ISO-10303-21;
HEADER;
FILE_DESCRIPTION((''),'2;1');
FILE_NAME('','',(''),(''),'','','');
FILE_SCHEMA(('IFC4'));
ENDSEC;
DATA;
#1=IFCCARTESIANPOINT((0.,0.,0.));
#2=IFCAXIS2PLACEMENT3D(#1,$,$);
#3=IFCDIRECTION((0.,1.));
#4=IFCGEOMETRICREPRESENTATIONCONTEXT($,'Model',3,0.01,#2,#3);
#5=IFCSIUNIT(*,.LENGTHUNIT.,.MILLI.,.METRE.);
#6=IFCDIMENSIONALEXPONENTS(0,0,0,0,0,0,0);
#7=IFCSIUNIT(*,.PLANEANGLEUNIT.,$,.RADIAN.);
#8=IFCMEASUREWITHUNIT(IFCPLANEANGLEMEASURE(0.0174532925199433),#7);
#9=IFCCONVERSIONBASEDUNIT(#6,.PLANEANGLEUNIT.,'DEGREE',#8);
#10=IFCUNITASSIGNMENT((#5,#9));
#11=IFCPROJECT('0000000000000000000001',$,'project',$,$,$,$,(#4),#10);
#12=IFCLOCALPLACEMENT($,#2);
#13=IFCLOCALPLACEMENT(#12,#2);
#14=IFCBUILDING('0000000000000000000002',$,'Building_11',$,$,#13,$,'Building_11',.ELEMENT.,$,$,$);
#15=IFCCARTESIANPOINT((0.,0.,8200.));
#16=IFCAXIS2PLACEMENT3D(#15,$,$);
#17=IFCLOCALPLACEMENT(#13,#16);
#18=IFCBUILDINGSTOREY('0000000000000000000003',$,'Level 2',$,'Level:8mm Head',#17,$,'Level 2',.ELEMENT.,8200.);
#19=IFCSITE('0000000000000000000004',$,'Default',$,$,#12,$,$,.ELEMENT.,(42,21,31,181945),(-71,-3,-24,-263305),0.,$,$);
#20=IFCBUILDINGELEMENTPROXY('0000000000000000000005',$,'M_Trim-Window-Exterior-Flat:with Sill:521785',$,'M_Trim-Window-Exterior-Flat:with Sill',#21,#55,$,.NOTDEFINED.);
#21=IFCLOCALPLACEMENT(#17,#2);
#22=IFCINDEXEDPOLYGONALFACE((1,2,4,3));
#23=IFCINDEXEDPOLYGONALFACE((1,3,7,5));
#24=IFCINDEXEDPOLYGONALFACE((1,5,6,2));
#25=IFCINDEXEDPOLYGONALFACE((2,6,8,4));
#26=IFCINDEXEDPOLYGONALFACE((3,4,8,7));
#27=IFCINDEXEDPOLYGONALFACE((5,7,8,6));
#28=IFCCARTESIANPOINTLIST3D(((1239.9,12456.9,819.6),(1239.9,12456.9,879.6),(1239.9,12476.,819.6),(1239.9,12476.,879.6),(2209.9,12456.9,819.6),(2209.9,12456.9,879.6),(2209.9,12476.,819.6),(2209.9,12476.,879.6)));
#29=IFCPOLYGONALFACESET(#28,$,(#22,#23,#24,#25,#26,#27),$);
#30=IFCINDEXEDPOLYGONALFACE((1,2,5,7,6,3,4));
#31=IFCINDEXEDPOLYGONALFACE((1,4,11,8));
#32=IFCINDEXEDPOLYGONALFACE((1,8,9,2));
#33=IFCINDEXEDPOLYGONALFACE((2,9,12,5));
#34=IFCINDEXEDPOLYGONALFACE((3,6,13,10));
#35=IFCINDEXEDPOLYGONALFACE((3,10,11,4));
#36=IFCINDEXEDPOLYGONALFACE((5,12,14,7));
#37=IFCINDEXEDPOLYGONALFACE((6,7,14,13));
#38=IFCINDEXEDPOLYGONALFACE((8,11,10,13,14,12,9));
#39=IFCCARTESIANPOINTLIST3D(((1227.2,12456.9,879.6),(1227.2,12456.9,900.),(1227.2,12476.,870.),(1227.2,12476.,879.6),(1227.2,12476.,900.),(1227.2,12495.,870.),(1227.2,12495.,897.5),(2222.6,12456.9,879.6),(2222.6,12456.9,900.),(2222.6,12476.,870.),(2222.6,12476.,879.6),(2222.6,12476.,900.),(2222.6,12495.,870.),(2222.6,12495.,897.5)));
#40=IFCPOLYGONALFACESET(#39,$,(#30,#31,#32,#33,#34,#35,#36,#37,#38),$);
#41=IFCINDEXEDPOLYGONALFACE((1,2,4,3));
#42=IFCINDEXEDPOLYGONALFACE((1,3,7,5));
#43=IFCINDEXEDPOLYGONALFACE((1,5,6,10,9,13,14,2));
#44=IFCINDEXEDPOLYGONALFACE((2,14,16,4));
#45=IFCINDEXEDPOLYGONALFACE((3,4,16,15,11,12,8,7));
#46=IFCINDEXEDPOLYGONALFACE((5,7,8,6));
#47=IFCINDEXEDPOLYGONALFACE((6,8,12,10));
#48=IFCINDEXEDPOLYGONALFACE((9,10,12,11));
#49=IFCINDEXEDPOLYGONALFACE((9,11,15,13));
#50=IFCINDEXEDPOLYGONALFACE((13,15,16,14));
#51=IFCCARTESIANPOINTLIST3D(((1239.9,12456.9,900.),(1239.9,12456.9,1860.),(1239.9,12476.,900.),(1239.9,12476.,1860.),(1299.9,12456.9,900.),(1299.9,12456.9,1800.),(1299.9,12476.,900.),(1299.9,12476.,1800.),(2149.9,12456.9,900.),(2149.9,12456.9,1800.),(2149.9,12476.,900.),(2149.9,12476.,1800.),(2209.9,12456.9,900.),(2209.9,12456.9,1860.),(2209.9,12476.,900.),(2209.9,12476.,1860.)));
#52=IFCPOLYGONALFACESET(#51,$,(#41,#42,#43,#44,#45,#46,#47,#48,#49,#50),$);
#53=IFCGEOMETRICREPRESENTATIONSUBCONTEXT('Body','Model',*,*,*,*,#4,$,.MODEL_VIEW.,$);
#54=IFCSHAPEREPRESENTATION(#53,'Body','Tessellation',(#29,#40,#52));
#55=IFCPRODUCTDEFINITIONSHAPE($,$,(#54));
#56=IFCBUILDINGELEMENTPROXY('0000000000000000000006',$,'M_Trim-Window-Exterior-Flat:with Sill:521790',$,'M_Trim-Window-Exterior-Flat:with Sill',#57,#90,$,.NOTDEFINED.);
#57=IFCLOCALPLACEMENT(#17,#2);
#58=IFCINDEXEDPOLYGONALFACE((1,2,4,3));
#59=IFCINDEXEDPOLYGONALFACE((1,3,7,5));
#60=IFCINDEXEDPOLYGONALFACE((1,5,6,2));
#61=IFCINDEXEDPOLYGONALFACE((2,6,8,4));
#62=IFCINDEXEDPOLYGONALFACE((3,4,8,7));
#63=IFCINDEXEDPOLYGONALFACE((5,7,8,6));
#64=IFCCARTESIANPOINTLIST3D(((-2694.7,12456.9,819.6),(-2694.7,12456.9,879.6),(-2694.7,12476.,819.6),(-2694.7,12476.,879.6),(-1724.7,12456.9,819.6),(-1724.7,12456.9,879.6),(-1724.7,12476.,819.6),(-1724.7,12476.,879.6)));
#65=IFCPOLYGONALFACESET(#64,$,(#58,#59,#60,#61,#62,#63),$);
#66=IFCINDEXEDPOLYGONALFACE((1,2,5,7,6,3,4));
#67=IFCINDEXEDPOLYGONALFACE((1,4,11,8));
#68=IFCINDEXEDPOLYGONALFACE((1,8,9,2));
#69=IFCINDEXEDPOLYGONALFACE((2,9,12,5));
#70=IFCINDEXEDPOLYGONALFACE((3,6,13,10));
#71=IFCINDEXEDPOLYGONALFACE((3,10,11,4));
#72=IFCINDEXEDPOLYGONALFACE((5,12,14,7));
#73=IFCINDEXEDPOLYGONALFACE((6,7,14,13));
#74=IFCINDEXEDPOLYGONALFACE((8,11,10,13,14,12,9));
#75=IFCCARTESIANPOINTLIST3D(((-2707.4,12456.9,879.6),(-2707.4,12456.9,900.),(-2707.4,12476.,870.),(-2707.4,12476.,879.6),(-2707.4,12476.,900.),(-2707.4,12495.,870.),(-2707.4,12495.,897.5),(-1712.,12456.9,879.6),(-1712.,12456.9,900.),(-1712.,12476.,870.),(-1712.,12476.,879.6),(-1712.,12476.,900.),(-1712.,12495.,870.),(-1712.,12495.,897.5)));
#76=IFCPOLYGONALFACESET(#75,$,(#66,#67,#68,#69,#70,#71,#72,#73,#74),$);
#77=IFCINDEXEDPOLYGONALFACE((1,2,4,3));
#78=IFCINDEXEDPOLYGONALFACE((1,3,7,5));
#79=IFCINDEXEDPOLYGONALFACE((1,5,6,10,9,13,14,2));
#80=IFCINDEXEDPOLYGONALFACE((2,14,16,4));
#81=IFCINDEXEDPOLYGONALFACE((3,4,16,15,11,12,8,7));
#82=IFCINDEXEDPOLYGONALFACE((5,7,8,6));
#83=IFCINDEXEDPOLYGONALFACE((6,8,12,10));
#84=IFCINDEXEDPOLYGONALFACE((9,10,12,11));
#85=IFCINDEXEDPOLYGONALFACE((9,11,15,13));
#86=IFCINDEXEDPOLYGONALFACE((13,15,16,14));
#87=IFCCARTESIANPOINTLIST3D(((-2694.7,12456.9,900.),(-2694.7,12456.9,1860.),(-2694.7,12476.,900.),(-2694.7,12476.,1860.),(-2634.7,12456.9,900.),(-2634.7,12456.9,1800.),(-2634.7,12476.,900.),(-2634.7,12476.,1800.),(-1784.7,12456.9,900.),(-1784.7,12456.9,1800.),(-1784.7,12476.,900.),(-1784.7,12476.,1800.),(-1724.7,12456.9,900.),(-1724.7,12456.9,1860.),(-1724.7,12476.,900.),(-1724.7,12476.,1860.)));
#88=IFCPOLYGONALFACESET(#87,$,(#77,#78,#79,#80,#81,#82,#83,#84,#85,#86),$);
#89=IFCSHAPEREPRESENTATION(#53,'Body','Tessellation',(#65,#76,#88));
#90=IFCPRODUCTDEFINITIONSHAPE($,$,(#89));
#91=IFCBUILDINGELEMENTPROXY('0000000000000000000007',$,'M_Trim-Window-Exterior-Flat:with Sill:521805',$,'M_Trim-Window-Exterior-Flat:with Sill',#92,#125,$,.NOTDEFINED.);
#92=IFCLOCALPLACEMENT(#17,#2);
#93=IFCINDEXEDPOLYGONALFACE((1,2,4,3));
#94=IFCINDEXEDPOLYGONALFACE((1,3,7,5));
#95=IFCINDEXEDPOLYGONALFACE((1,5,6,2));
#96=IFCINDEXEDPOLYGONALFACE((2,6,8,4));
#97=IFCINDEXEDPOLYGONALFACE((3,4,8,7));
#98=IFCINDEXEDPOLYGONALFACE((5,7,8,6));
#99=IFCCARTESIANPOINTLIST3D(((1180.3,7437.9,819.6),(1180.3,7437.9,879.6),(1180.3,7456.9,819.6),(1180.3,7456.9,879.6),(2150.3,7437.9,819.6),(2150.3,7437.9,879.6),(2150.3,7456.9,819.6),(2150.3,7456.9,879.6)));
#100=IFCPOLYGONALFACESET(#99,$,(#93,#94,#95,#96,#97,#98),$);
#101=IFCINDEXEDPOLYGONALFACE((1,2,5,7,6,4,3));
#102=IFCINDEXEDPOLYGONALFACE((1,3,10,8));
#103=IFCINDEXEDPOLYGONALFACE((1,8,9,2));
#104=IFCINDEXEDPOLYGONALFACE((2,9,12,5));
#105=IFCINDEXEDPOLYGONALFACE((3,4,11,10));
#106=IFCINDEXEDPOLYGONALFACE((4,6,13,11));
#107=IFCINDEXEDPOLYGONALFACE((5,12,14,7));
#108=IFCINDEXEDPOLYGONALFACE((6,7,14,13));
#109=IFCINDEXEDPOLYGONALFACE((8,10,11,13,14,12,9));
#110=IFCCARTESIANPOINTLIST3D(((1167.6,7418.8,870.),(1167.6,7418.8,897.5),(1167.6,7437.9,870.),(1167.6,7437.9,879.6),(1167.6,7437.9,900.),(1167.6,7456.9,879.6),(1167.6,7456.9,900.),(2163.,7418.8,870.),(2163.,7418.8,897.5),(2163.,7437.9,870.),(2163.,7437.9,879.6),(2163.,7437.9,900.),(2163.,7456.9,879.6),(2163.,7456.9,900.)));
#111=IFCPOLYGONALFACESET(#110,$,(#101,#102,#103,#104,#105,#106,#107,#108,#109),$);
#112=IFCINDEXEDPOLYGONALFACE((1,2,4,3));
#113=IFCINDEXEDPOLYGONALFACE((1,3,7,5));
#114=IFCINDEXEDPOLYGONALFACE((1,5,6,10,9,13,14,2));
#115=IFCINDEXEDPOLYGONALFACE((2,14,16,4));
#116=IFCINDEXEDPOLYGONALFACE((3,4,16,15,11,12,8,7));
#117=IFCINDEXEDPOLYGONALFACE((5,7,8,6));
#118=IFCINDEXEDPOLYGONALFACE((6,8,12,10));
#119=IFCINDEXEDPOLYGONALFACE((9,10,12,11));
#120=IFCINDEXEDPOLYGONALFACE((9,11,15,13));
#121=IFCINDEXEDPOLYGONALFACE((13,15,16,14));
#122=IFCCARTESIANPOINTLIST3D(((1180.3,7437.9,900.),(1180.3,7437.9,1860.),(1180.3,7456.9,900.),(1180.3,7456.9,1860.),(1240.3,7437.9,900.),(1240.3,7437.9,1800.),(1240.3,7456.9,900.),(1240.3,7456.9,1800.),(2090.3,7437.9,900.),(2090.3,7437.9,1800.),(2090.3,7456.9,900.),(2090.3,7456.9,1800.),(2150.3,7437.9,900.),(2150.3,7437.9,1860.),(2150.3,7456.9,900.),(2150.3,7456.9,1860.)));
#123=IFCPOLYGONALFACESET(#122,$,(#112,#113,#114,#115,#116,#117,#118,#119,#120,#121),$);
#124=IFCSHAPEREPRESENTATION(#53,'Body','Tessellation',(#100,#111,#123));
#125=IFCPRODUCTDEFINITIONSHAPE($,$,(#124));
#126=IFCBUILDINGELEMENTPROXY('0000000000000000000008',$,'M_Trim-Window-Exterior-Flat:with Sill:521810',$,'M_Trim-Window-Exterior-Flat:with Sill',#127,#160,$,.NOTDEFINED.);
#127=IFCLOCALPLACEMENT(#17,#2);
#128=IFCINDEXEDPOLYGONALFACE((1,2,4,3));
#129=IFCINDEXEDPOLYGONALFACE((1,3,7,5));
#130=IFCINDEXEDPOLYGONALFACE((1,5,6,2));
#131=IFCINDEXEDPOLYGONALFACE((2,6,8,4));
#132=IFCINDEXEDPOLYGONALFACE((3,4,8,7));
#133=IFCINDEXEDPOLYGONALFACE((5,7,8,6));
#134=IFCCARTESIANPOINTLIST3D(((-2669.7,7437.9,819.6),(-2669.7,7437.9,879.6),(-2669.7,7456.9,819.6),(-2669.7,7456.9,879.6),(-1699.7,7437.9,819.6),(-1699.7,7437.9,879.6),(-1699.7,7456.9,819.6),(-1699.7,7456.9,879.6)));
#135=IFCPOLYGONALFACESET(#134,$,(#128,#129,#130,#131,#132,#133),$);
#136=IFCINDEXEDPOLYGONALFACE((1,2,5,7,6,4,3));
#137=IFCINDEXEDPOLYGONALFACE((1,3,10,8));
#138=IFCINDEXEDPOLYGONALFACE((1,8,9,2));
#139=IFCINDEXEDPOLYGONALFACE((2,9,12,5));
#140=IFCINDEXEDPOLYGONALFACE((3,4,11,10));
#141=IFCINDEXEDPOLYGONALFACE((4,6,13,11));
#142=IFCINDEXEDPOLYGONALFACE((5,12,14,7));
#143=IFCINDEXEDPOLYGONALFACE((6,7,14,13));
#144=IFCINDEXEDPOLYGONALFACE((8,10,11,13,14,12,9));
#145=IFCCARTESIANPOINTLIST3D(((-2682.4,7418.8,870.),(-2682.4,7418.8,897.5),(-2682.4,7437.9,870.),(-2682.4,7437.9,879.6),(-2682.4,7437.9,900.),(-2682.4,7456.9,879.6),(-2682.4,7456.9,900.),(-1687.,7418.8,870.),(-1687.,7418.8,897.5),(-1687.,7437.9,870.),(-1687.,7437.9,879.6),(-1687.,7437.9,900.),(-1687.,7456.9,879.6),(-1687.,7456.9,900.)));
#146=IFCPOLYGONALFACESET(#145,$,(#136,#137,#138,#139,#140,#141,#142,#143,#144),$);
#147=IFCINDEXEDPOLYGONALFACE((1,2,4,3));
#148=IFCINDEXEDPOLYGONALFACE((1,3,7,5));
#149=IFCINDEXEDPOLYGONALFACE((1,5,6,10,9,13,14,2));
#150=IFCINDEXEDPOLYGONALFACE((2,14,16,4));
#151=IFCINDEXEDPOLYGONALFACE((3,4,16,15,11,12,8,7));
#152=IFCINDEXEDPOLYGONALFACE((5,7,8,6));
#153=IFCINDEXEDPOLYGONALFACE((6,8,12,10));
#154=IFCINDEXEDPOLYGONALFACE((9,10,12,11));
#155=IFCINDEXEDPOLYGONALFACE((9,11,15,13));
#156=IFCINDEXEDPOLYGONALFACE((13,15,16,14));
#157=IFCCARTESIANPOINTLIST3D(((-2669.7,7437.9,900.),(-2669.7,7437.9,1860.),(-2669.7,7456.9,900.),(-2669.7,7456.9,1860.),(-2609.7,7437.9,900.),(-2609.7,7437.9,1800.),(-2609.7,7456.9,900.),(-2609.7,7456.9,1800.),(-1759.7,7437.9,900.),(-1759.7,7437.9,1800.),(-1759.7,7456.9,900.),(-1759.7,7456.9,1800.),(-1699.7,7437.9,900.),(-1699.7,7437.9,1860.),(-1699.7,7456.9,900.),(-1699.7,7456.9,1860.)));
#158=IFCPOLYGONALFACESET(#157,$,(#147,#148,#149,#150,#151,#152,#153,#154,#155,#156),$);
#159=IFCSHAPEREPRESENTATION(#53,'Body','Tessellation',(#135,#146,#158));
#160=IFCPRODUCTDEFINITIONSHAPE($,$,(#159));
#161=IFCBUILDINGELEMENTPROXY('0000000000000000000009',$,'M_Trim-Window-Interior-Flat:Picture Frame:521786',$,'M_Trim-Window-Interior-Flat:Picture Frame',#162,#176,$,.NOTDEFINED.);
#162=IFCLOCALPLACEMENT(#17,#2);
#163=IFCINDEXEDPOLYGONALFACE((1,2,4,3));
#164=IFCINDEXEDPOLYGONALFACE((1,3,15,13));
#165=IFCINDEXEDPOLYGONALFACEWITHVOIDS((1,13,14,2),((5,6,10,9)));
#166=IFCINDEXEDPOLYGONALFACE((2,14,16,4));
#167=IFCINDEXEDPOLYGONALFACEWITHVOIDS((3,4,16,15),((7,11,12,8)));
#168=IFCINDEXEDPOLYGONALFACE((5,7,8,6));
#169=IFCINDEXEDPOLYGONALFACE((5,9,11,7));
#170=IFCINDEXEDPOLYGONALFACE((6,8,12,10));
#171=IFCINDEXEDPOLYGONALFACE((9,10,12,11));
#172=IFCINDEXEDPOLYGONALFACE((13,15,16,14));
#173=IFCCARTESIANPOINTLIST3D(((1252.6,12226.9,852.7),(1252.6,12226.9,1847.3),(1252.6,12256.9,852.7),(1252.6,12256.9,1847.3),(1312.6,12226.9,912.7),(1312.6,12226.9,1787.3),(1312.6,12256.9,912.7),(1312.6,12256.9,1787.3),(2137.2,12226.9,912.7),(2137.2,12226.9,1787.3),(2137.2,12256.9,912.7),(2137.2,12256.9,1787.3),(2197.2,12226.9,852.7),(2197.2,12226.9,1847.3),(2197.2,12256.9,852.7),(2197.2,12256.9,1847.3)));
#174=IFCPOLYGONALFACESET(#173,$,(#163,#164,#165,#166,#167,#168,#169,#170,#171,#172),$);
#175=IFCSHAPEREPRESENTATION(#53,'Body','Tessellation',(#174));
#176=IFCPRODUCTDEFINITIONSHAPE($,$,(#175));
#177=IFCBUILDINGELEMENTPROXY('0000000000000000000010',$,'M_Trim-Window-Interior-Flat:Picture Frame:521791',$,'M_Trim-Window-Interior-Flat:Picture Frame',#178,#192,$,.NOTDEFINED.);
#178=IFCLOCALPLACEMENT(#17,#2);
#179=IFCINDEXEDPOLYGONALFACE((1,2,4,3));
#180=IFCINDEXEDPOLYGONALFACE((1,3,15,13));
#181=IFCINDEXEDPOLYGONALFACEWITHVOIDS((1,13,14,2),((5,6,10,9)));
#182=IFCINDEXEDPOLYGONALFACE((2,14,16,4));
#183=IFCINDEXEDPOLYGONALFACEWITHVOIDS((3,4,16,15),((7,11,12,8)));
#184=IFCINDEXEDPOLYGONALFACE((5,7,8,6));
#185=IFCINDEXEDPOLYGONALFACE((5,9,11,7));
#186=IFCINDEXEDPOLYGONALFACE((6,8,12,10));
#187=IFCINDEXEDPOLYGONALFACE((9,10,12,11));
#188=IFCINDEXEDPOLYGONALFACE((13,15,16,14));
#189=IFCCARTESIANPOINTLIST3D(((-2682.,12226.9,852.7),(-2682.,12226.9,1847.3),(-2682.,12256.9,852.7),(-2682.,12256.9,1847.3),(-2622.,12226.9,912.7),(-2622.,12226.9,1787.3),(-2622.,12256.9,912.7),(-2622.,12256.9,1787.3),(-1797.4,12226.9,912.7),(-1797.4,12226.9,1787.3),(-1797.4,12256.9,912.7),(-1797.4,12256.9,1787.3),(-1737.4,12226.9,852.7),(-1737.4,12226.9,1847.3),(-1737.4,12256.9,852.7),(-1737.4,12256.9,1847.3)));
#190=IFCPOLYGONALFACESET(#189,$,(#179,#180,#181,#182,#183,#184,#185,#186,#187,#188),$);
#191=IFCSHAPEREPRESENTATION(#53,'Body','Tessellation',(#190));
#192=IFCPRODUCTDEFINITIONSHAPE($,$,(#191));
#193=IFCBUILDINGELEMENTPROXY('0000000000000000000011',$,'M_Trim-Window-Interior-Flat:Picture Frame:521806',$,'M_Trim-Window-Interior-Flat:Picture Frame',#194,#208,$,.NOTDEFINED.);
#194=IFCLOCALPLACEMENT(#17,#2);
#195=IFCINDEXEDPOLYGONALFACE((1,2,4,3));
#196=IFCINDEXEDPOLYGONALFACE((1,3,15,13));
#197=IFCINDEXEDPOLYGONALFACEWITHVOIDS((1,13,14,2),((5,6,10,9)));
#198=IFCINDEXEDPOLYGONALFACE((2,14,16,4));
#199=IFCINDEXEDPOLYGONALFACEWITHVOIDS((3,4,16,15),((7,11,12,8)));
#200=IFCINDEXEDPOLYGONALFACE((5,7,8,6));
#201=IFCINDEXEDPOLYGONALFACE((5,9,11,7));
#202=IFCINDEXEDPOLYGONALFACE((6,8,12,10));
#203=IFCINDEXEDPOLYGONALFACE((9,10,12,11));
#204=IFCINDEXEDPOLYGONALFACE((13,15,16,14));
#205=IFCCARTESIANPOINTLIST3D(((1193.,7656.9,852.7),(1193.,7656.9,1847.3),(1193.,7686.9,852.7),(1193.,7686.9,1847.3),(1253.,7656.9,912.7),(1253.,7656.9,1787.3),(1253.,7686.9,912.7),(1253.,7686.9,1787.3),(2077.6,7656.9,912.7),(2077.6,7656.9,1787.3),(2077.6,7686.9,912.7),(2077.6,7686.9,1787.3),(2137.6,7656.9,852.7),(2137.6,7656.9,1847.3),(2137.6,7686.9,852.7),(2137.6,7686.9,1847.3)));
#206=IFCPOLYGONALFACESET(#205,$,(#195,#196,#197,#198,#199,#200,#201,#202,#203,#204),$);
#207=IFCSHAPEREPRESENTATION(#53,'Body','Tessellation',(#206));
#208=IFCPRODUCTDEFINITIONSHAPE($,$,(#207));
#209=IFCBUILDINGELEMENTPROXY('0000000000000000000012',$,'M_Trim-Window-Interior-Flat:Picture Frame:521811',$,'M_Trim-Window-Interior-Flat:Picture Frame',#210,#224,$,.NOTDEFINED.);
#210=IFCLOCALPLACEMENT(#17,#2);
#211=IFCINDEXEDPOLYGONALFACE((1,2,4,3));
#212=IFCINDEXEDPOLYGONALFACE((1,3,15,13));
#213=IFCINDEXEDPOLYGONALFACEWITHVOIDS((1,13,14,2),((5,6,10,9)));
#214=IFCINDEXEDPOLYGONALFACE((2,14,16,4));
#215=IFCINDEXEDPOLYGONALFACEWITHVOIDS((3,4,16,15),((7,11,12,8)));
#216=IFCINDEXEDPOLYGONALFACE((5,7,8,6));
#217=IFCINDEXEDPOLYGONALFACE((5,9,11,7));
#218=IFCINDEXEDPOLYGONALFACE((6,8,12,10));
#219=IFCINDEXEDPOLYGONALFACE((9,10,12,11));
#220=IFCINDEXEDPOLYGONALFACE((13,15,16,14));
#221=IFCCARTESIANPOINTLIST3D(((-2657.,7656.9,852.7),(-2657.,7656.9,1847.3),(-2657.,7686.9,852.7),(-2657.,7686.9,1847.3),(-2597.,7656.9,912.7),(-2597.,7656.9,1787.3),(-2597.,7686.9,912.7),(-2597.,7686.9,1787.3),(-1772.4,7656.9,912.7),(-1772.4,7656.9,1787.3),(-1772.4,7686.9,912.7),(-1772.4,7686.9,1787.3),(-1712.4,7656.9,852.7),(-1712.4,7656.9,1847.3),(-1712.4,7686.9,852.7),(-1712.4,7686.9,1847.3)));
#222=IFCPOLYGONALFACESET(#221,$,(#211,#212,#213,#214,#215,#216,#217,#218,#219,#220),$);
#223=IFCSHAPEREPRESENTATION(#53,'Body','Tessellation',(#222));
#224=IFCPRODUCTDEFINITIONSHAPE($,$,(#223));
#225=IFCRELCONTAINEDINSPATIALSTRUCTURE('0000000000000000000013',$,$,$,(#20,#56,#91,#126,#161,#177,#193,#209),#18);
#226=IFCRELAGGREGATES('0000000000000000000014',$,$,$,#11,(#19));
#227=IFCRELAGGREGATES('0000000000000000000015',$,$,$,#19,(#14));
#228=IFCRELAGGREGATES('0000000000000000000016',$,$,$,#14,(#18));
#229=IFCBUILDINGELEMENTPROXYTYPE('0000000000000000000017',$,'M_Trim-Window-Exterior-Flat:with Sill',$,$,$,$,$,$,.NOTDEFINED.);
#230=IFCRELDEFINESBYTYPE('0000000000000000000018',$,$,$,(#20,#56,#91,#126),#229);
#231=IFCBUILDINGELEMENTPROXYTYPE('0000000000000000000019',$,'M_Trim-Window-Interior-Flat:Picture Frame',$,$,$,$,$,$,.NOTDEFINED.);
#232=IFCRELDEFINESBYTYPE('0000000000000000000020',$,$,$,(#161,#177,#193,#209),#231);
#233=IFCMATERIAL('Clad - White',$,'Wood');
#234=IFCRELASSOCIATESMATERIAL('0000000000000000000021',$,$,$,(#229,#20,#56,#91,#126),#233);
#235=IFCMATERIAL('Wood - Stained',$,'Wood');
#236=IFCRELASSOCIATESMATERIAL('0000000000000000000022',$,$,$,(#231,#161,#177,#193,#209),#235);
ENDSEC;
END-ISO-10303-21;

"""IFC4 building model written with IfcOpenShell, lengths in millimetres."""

from ifc_helpers import new_model, entity, si_unit, converted_unit, direction, frame, origin, place, context, subcontext, project, spatial, indexed_curve, outline, extrude, source, transform, mapped, material, type_object, type_shapes, element, save


model = new_model("IFC4")

# Units and contexts
model_context = context("Model", 3, precision=0.01, world=origin(), true_north=direction((0.0, 1.0)))
body_context = subcontext(model_context, "Body", "Model", "MODEL_VIEW")
ifc_project = project(units=[si_unit("LENGTHUNIT", "METRE", prefix="MILLI"), converted_unit("PLANEANGLEUNIT", "DEGREE", entity("IfcPlaneAngleMeasure", 0.0174532925199433), si_unit("PLANEANGLEUNIT", "RADIAN"), dimensions=[0, 0, 0, 0, 0, 0, 0])], contexts=[model_context])

# Site, building, storey
site_placement = place(None, origin())
site = spatial("IfcSite", under=ifc_project, at=site_placement, Name="Default", CompositionType="ELEMENT", RefLatitude=(42, 21, 31, 181945), RefLongitude=(-71, -3, -24, -263305), RefElevation=0.0)
building_placement = place(site_placement, origin())
building = spatial("IfcBuilding", under=site, at=building_placement, Name="Building_11", LongName="Building_11", CompositionType="ELEMENT")
storey_placement = place(building_placement, frame((0.0, 0.0, 8200.0)))
storey = spatial("IfcBuildingStorey", under=building, at=storey_placement, Name="Level 2", ObjectType="Level:8mm Head", LongName="Level 2", CompositionType="ELEMENT", Elevation=8200.0)

# Building element proxies
ifc_material_1 = material(Name="Clad - White", Category="Wood")
ifc_material_2 = material(Name="Wood - Stained", Category="Wood")
building_element_proxy_type_1 = type_object("IfcBuildingElementProxyType", Name="M_Trim-Window-Exterior-Flat:with Sill", PredefinedType="NOTDEFINED", material=ifc_material_1)
shared_shape_1 = source(origin(), body_context, "Body", "SweptSolid", [
    extrude(outline(indexed_curve([(-485.0, -30.0), (485.0, -30.0), (485.0, 30.0), (-485.0, 30.0), (-485.0, -30.0)], self_intersect=False)), frame((0.0, -950.4, 0.0), z_axis=(0.0, 0.0, 1.0), x_axis=(-1.0, 0.0, 0.0)), (0.0, 0.0, 1.0), 19.1),
    extrude(outline(indexed_curve([(-19.0, -15.2), (0.0, -15.2), (0.0, -5.7), (19.0, -5.7), (19.0, 14.8), (0.0, 14.8), (-19.0, 12.3), (-19.0, -15.2)], self_intersect=False)), frame((-497.7, -914.8, 19.0), z_axis=(1.0, 0.0, 0.0), x_axis=(0.0, 0.0, -1.0)), (0.0, 0.0, 1.0), 995.4),
    extrude(outline(indexed_curve([(-495.0, -485.0), (465.0, -485.0), (465.0, -425.0), (-435.0, -425.0), (-435.0, 425.0), (465.0, 425.0), (465.0, 485.0), (-495.0, 485.0), (-495.0, -485.0)], self_intersect=False)), frame((0.0, -435.0, 0.0), z_axis=(0.0, 0.0, 1.0), x_axis=(0.0, -1.0, 0.0)), (0.0, 0.0, 1.0), 19.1),
])
type_shapes(building_element_proxy_type_1, [shared_shape_1])
for number, where, z_axis, x_axis, name in (
    (1, (1724.9, 12456.9, 1800.0), (0.0, 1.0, 0.0), (-1.0, 0.0, 0.0), "M_Trim-Window-Exterior-Flat:with Sill:521785"),
    (2, (-2209.7, 12456.9, 1800.0), (0.0, 1.0, 0.0), (-1.0, 0.0, 0.0), "M_Trim-Window-Exterior-Flat:with Sill:521790"),
    (3, (1665.3, 7456.9, 1800.0), (0.0, -1.0, 0.0), (1.0, 0.0, 0.0), "M_Trim-Window-Exterior-Flat:with Sill:521805"),
    (4, (-2184.7, 7456.9, 1800.0), (0.0, -1.0, 0.0), (1.0, 0.0, 0.0), "M_Trim-Window-Exterior-Flat:with Sill:521810"),
):
    element("IfcBuildingElementProxy", number, at=place(storey_placement, frame(where, z_axis=z_axis, x_axis=x_axis)), inside=storey, type_object=building_element_proxy_type_1, material=ifc_material_1, Name=name, ObjectType="M_Trim-Window-Exterior-Flat:with Sill", PredefinedType="NOTDEFINED", context=body_context, shape_type="MappedRepresentation", body=[
        mapped(shared_shape_1, transform((0.0, 0.0, 0.0), scale=1.0)),
    ])
building_element_proxy_type_2 = type_object("IfcBuildingElementProxyType", Name="M_Trim-Window-Interior-Flat:Picture Frame", PredefinedType="NOTDEFINED", material=ifc_material_2)
shared_shape_2 = source(origin(), body_context, "Body", "SweptSolid", [
    extrude(outline(indexed_curve([(-472.3, -497.3), (472.3, -497.3), (472.3, 497.3), (-472.3, 497.3), (-472.3, -497.3)], self_intersect=False), holes=[indexed_curve([(-412.3, -437.3), (-412.3, 437.3), (412.3, 437.3), (412.3, -437.3), (-412.3, -437.3)], self_intersect=False)]), frame((0.0, -450.0, 0.0), z_axis=(0.0, 0.0, 1.0), x_axis=(-1.0, 0.0, 0.0)), (0.0, 0.0, 1.0), 30.0),
])
type_shapes(building_element_proxy_type_2, [shared_shape_2])
for number, where, z_axis, x_axis, name in (
    (5, (1724.9, 12256.9, 1800.0), (0.0, -1.0, 0.0), (1.0, 0.0, 0.0), "M_Trim-Window-Interior-Flat:Picture Frame:521786"),
    (6, (-2209.7, 12256.9, 1800.0), (0.0, -1.0, 0.0), (1.0, 0.0, 0.0), "M_Trim-Window-Interior-Flat:Picture Frame:521791"),
    (7, (1665.3, 7656.9, 1800.0), (0.0, 1.0, 0.0), (-1.0, 0.0, 0.0), "M_Trim-Window-Interior-Flat:Picture Frame:521806"),
    (8, (-2184.7, 7656.9, 1800.0), (0.0, 1.0, 0.0), (-1.0, 0.0, 0.0), "M_Trim-Window-Interior-Flat:Picture Frame:521811"),
):
    element("IfcBuildingElementProxy", number, at=place(storey_placement, frame(where, z_axis=z_axis, x_axis=x_axis)), inside=storey, type_object=building_element_proxy_type_2, material=ifc_material_2, Name=name, ObjectType="M_Trim-Window-Interior-Flat:Picture Frame", PredefinedType="NOTDEFINED", context=body_context, shape_type="MappedRepresentation", body=[
        mapped(shared_shape_2, transform((0.0, 0.0, 0.0), scale=1.0)),
    ])

save(model, "model.ifc")
